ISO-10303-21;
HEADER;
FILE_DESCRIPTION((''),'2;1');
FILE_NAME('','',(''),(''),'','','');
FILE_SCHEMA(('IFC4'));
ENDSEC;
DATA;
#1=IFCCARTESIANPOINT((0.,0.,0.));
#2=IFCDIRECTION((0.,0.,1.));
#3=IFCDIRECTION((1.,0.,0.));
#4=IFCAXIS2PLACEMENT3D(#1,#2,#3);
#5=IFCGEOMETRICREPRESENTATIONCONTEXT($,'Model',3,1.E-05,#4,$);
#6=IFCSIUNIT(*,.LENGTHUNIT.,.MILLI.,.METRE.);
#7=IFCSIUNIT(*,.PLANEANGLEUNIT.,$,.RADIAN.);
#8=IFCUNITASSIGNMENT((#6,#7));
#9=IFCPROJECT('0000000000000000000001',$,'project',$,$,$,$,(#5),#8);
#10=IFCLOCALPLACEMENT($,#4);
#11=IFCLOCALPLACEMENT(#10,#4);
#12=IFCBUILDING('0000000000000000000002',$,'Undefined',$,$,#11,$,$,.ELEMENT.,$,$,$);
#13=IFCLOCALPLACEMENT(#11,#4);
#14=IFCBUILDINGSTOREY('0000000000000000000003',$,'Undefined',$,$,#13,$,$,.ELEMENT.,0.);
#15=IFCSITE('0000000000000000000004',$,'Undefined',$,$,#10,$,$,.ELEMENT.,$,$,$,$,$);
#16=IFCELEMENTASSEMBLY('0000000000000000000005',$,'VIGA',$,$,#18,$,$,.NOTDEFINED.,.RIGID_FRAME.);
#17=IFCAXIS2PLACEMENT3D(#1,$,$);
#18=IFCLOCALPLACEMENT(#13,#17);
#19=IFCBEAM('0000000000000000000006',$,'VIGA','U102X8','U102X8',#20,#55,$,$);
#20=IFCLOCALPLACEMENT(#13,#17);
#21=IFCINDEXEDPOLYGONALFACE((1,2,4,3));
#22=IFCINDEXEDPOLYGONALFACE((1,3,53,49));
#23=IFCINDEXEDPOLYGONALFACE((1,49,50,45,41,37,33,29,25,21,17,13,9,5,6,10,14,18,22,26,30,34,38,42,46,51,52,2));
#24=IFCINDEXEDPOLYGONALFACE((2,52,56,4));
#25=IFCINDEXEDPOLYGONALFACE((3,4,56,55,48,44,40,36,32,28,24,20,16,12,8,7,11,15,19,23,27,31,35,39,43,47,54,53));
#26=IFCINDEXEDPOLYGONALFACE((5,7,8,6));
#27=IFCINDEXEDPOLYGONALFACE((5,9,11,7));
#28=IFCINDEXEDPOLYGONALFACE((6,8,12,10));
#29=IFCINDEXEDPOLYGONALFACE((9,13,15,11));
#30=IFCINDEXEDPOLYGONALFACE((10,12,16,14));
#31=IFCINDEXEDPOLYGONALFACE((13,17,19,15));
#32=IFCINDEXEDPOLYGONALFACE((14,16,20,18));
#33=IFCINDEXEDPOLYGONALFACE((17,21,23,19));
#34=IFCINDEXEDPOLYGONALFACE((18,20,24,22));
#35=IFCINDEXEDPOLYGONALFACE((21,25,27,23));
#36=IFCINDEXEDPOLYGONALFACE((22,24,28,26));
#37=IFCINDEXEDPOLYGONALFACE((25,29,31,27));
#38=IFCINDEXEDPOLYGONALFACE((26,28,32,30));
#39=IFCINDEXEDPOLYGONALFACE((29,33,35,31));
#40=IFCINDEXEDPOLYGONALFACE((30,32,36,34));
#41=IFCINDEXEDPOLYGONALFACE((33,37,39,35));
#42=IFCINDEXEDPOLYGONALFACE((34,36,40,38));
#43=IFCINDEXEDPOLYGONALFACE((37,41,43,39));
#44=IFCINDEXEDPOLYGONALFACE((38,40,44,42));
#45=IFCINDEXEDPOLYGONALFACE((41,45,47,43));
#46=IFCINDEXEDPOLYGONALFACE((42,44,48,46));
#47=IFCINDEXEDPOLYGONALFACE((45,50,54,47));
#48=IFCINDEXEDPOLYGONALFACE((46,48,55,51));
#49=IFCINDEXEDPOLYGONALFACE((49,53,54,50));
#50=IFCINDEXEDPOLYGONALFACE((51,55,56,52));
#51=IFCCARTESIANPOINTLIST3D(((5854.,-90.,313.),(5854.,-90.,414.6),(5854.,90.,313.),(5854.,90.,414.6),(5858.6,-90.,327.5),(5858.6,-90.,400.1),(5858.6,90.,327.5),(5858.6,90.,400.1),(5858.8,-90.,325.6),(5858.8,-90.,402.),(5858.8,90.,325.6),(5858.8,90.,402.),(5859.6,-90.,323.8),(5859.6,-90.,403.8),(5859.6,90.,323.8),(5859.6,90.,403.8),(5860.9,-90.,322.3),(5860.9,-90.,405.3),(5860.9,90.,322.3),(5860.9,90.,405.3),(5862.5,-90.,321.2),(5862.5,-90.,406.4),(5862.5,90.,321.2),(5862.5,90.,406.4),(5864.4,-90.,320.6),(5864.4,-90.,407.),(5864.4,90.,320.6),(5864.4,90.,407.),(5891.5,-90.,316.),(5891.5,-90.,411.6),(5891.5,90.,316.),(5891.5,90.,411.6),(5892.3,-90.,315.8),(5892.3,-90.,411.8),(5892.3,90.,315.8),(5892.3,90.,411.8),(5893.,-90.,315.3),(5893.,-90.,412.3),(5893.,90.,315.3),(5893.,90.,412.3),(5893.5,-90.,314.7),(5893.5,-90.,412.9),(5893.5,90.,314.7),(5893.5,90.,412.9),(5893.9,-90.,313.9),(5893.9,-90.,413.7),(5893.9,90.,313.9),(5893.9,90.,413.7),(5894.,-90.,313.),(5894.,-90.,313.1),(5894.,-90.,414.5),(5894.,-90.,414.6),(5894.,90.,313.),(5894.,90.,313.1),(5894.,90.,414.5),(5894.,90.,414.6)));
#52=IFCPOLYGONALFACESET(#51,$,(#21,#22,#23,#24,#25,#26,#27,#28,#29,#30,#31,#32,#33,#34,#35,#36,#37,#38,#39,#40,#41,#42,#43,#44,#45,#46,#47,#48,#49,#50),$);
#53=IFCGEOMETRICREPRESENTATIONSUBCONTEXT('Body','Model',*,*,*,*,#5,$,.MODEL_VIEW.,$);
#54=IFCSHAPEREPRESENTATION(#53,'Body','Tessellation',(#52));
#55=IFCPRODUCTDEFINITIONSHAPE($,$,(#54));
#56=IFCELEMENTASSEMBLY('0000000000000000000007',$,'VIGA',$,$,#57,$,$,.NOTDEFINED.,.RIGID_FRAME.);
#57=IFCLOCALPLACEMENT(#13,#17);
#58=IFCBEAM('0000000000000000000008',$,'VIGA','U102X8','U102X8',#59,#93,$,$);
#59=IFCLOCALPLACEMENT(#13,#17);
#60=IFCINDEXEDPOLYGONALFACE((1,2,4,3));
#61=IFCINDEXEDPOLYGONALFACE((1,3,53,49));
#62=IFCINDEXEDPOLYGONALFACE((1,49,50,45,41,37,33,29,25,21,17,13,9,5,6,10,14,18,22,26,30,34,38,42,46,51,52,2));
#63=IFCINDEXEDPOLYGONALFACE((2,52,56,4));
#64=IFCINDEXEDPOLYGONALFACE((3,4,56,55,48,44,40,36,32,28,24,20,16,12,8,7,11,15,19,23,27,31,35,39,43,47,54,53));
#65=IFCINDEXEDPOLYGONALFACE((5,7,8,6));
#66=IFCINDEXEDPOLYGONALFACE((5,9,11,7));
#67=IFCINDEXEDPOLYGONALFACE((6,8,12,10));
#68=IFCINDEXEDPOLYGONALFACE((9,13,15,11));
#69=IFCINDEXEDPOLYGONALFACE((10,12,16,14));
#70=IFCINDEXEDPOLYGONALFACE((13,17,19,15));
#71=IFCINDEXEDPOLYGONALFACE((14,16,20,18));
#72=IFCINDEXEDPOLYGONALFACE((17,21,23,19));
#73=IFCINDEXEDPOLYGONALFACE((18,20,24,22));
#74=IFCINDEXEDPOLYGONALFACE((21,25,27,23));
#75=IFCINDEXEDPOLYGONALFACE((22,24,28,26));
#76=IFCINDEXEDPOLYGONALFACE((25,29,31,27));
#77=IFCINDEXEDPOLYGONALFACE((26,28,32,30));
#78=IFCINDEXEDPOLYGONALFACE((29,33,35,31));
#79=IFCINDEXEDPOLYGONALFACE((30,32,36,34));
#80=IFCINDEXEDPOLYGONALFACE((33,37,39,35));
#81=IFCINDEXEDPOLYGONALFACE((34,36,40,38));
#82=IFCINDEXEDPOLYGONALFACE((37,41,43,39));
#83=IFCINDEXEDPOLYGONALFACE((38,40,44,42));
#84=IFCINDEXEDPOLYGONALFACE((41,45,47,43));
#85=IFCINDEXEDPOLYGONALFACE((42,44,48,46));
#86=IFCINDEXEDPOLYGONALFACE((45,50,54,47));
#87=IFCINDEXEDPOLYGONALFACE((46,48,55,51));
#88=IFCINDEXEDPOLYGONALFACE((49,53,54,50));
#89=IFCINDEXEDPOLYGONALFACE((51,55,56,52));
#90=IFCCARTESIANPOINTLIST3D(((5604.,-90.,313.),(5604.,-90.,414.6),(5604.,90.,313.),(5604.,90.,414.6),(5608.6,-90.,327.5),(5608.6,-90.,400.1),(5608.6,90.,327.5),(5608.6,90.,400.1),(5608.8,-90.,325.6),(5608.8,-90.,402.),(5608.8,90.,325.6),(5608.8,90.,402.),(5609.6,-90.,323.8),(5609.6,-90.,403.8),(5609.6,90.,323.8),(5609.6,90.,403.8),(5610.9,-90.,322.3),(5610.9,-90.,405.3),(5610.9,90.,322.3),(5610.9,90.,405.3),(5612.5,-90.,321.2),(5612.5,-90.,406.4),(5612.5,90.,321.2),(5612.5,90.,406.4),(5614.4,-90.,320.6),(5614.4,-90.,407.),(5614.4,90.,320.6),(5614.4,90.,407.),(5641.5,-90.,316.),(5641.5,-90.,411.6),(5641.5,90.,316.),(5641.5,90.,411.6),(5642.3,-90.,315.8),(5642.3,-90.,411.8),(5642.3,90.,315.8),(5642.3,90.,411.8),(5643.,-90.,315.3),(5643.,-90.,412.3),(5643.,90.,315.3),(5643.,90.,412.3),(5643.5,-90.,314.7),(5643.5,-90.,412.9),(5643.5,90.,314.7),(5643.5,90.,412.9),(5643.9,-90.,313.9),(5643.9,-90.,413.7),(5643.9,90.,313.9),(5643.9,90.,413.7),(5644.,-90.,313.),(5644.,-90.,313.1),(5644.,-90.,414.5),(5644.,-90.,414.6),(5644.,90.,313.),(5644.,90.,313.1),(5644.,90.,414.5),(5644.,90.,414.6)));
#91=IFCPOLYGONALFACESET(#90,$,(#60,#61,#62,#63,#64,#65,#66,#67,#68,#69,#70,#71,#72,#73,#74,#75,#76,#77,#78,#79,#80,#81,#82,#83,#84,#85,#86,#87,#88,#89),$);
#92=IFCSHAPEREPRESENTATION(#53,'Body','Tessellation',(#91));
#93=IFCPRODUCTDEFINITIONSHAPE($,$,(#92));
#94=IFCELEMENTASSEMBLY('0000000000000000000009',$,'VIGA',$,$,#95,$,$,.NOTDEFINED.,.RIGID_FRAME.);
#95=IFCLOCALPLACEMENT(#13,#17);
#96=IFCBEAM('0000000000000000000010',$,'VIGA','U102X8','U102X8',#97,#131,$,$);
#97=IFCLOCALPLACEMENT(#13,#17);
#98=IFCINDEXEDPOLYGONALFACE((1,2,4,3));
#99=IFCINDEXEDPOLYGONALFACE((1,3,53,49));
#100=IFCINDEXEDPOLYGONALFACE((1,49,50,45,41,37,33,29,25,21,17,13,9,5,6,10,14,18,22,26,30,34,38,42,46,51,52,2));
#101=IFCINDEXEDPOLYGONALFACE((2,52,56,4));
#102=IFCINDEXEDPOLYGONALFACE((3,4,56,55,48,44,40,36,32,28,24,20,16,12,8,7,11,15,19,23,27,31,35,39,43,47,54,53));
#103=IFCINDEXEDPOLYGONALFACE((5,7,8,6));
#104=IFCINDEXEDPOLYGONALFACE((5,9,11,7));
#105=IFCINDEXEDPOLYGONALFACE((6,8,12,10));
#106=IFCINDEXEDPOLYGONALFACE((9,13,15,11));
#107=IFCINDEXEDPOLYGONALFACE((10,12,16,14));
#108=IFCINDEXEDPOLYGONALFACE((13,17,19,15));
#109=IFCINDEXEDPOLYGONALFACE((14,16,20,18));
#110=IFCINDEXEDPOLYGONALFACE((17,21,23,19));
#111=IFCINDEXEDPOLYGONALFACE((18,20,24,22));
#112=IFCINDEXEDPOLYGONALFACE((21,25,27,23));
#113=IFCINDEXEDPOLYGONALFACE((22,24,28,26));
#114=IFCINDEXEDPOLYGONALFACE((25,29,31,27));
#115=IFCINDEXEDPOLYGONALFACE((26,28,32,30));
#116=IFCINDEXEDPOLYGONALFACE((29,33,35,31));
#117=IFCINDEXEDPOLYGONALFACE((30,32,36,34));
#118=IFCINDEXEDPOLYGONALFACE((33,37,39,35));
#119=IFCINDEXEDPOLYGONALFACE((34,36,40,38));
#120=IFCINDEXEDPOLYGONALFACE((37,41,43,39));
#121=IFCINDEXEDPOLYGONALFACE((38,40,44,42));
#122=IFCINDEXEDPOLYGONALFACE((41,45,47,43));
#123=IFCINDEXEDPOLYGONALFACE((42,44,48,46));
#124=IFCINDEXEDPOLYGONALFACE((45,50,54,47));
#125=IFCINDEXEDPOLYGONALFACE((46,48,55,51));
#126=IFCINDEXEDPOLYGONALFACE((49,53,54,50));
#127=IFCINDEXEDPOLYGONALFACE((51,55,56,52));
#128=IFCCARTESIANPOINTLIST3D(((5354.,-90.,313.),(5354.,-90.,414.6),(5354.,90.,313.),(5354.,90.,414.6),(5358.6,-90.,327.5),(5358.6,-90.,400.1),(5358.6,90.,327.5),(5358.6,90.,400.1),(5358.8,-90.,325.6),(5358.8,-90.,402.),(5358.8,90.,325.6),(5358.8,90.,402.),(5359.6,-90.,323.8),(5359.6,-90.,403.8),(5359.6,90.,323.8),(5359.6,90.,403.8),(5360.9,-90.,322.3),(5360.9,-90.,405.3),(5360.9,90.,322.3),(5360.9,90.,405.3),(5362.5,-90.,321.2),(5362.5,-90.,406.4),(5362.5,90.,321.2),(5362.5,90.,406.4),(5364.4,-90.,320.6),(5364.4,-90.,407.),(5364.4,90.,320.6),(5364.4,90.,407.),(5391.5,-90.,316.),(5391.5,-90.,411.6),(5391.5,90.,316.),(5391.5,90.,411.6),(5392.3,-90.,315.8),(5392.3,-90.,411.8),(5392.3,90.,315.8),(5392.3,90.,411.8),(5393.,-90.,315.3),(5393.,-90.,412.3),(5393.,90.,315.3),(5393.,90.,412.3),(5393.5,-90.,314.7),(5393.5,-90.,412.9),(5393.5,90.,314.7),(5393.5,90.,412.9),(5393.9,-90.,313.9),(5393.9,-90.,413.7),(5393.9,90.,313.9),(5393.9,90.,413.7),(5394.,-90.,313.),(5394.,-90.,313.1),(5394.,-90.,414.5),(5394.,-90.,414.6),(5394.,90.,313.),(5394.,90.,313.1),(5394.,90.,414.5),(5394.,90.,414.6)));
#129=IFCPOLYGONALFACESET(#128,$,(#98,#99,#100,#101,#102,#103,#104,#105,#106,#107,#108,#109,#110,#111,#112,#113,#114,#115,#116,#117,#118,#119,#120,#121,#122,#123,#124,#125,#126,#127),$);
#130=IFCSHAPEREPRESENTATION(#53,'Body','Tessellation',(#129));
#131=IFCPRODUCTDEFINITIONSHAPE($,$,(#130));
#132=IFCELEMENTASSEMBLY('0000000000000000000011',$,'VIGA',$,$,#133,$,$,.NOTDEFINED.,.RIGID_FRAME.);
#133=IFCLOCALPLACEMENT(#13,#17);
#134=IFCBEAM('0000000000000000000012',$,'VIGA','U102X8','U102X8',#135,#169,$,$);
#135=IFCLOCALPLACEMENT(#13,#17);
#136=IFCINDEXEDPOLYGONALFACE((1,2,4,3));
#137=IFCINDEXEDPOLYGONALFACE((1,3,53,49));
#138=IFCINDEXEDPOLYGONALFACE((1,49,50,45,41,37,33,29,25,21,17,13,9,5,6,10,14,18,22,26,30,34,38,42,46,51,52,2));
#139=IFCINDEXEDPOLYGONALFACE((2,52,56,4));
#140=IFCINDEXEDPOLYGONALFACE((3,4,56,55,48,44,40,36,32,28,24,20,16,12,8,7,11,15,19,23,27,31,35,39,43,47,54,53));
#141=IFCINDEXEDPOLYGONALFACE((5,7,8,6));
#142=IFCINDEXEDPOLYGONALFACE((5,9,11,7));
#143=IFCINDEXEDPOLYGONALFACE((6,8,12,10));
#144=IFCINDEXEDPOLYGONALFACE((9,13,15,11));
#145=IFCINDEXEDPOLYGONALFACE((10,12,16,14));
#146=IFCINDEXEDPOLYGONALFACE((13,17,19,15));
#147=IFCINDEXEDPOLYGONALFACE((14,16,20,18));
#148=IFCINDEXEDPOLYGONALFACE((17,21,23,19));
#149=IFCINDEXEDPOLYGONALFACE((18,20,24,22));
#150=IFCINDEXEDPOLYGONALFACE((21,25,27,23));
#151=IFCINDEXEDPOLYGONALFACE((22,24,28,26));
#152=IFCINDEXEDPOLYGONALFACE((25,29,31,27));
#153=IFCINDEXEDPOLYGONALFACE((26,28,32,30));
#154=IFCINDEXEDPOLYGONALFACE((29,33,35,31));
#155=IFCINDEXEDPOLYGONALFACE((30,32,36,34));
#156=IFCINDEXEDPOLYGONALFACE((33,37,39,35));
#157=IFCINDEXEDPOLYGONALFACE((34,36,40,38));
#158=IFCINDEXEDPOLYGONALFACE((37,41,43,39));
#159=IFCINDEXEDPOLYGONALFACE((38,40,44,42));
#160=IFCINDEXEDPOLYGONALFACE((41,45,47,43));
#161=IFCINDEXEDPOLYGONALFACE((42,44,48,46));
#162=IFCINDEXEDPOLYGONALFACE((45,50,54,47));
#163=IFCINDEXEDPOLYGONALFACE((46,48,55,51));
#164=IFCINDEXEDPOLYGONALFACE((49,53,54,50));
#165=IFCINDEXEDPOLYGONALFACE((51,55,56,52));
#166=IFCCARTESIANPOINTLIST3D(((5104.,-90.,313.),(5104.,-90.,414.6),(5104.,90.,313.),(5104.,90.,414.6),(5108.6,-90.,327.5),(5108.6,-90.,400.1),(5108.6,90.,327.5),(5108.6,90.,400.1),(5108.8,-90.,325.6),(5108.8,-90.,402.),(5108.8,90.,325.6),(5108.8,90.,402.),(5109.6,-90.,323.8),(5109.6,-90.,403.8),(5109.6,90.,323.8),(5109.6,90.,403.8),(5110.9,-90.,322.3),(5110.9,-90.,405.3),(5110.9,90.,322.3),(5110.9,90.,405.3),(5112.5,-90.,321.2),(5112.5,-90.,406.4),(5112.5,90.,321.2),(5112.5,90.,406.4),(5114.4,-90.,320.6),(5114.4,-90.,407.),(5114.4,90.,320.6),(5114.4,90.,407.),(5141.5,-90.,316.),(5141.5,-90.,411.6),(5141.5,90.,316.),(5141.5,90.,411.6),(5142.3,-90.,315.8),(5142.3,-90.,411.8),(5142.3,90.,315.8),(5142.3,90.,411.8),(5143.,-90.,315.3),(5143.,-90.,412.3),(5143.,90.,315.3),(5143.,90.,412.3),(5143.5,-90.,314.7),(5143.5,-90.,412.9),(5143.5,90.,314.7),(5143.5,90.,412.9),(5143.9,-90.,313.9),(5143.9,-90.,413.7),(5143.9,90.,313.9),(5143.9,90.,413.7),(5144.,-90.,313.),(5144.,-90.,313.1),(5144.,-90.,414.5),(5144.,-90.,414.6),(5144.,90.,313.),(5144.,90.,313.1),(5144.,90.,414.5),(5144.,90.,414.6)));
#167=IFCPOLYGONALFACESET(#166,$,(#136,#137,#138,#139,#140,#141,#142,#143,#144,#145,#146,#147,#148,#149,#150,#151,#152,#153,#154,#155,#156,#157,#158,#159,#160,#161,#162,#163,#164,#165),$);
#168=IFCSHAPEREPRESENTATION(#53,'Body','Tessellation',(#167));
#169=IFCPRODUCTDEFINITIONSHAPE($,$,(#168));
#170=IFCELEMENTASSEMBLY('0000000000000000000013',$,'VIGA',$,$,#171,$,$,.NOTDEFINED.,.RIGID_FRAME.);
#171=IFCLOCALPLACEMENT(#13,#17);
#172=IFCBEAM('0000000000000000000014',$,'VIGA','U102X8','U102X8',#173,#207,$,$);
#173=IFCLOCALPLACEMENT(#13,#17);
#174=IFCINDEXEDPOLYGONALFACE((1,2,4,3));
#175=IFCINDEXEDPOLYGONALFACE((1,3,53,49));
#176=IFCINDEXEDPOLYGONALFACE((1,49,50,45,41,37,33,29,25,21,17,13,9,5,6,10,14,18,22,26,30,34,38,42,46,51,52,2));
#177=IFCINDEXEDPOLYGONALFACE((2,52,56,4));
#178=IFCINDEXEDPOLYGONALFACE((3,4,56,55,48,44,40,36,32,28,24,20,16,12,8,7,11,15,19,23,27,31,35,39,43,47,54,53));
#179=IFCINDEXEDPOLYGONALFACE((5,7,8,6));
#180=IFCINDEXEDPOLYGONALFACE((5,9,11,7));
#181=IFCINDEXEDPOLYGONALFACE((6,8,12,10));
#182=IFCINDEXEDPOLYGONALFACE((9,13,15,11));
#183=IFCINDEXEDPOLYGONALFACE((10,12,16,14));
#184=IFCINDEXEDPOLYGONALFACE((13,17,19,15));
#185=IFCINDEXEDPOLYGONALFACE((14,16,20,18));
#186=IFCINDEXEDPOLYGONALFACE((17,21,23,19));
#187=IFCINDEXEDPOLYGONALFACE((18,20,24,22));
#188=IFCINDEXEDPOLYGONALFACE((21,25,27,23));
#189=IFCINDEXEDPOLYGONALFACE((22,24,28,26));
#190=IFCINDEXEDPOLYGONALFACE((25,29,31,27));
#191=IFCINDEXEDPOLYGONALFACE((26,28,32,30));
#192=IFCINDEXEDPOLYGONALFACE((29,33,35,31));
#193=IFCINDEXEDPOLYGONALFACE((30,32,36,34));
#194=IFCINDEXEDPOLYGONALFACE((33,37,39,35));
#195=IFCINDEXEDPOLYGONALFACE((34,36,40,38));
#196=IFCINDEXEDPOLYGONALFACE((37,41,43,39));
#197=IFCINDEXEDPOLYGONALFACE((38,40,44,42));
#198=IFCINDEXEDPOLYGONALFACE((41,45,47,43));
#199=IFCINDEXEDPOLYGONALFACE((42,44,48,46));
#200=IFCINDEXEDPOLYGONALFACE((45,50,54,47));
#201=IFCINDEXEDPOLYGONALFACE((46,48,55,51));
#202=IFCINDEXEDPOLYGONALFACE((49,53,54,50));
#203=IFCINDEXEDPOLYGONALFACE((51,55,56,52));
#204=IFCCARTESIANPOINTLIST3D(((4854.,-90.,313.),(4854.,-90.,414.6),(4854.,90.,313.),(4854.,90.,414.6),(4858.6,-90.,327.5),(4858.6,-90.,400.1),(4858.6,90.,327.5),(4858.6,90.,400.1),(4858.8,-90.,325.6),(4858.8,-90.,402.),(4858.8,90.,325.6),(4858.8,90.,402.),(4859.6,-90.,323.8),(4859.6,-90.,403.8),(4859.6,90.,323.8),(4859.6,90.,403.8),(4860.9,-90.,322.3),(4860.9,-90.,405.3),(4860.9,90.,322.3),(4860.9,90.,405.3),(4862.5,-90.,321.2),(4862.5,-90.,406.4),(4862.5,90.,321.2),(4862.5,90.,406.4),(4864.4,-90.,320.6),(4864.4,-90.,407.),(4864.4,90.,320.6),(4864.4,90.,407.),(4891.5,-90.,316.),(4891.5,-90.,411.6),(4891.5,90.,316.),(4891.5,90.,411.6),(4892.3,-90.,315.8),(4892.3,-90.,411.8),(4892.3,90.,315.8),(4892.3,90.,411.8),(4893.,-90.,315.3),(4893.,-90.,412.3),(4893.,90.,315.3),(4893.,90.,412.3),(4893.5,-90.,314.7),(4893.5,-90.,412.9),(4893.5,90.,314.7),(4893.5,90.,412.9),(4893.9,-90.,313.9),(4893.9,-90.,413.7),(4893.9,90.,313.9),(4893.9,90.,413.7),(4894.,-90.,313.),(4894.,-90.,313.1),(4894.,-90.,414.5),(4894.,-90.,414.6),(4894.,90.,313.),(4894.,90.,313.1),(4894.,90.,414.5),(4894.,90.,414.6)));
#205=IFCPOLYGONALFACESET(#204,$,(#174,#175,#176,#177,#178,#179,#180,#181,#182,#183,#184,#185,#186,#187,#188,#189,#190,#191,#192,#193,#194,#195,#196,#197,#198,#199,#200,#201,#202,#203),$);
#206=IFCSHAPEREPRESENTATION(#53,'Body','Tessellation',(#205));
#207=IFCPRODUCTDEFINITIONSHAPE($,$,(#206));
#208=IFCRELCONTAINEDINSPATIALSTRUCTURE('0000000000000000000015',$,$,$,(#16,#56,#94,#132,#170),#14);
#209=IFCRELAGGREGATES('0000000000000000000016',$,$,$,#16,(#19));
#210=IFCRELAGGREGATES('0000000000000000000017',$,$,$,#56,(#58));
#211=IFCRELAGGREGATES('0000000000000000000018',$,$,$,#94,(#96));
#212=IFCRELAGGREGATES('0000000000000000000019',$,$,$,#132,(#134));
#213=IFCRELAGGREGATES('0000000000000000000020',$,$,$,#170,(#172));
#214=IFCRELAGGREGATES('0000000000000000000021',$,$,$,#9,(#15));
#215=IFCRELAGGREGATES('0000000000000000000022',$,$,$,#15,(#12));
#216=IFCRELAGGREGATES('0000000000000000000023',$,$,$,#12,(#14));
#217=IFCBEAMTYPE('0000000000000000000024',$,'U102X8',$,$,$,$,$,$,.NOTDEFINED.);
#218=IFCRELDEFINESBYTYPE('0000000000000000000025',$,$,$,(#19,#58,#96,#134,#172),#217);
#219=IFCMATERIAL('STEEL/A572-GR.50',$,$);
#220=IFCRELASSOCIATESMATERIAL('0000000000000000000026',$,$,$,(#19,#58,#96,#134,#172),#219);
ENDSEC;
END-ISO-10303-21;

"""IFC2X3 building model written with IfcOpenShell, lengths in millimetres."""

from ifc_helpers import new_model, si_unit, frame, origin_with_axes, origin_2d_with_axis, place, context, subcontext, project, spatial, u_section, extrude, material, type_object, element, aggregate, save


model = new_model("IFC2X3")

# Units and contexts
model_context = context("Model", 3, precision=1e-05, world=origin_with_axes())
body_context = subcontext(model_context, "Body", "Model", "MODEL_VIEW")
ifc_project = project(units=[si_unit("LENGTHUNIT", "METRE", prefix="MILLI"), si_unit("PLANEANGLEUNIT", "RADIAN")], contexts=[model_context])

# Site, building, storey
site_placement = place(None, origin_with_axes())
site = spatial("IfcSite", under=ifc_project, at=site_placement, Name="Undefined", CompositionType="ELEMENT")
building_placement = place(site_placement, origin_with_axes())
building = spatial("IfcBuilding", under=site, at=building_placement, Name="Undefined", CompositionType="ELEMENT")
storey_placement = place(building_placement, origin_with_axes())
storey = spatial("IfcBuildingStorey", under=building, at=storey_placement, Name="Undefined", CompositionType="ELEMENT", Elevation=0.0)

# Element assemblies, beams
ifc_material_1 = material(Name="STEEL/A572-GR.50")
beam_type_1 = type_object("IfcBeamType", Name="U102X8", PredefinedType="NOTDEFINED")
assembly_1_placement = place(storey_placement, origin_with_axes())
assembly_1 = element("IfcElementAssembly", 1, at=assembly_1_placement, inside=storey, Name="VIGA", AssemblyPlace="NOTDEFINED", PredefinedType="RIGID_FRAME")
beam_1_placement = place(assembly_1_placement, frame((5874.0, -90.0, 363.8), z_axis=(0.0, 0.0, 1.0), x_axis=(0.0, 1.0, 0.0)))
beam_1 = element("IfcBeam", 2, at=beam_1_placement, type_object=beam_type_1, material=ifc_material_1, Name="VIGA", Description="U102X8", ObjectType="U102X8", context=body_context, shape_type="SweptSolid", body=[
    extrude(u_section(Depth=101.6, FlangeWidth=40.0, WebThickness=4.6, FlangeThickness=6.0, FilletRadius=7.0, EdgeRadius=3.0, FlangeSlope=0.16839, at=origin_2d_with_axis()), frame((180.0, 0.0, 0.0), z_axis=(-1.0, 0.0, 0.0), x_axis=(0.0, -1.0, 0.0)), (0.0, 0.0, 1.0), 180.0),
])
aggregate(assembly_1, [beam_1])
assembly_2_placement = place(storey_placement, origin_with_axes())
assembly_2 = element("IfcElementAssembly", 3, at=assembly_2_placement, inside=storey, Name="VIGA", AssemblyPlace="NOTDEFINED", PredefinedType="RIGID_FRAME")
beam_2_placement = place(assembly_2_placement, frame((5624.0, -90.0, 363.8), z_axis=(0.0, 0.0, 1.0), x_axis=(0.0, 1.0, 0.0)))
beam_2 = element("IfcBeam", 4, at=beam_2_placement, type_object=beam_type_1, material=ifc_material_1, Name="VIGA", Description="U102X8", ObjectType="U102X8", context=body_context, shape_type="SweptSolid", body=[
    extrude(u_section(Depth=101.6, FlangeWidth=40.0, WebThickness=4.6, FlangeThickness=6.0, FilletRadius=7.0, EdgeRadius=3.0, FlangeSlope=0.16839, at=origin_2d_with_axis()), frame((180.0, 0.0, 0.0), z_axis=(-1.0, 0.0, 0.0), x_axis=(0.0, -1.0, 0.0)), (0.0, 0.0, 1.0), 180.0),
])
aggregate(assembly_2, [beam_2])
assembly_3_placement = place(storey_placement, origin_with_axes())
assembly_3 = element("IfcElementAssembly", 5, at=assembly_3_placement, inside=storey, Name="VIGA", AssemblyPlace="NOTDEFINED", PredefinedType="RIGID_FRAME")
beam_3_placement = place(assembly_3_placement, frame((5374.0, -90.0, 363.8), z_axis=(0.0, 0.0, 1.0), x_axis=(0.0, 1.0, 0.0)))
beam_3 = element("IfcBeam", 6, at=beam_3_placement, type_object=beam_type_1, material=ifc_material_1, Name="VIGA", Description="U102X8", ObjectType="U102X8", context=body_context, shape_type="SweptSolid", body=[
    extrude(u_section(Depth=101.6, FlangeWidth=40.0, WebThickness=4.6, FlangeThickness=6.0, FilletRadius=7.0, EdgeRadius=3.0, FlangeSlope=0.16839, at=origin_2d_with_axis()), frame((180.0, 0.0, 0.0), z_axis=(-1.0, 0.0, 0.0), x_axis=(0.0, -1.0, 0.0)), (0.0, 0.0, 1.0), 180.0),
])
aggregate(assembly_3, [beam_3])
assembly_4_placement = place(storey_placement, origin_with_axes())
assembly_4 = element("IfcElementAssembly", 7, at=assembly_4_placement, inside=storey, Name="VIGA", AssemblyPlace="NOTDEFINED", PredefinedType="RIGID_FRAME")
beam_4_placement = place(assembly_4_placement, frame((5124.0, -90.0, 363.8), z_axis=(0.0, 0.0, 1.0), x_axis=(0.0, 1.0, 0.0)))
beam_4 = element("IfcBeam", 8, at=beam_4_placement, type_object=beam_type_1, material=ifc_material_1, Name="VIGA", Description="U102X8", ObjectType="U102X8", context=body_context, shape_type="SweptSolid", body=[
    extrude(u_section(Depth=101.6, FlangeWidth=40.0, WebThickness=4.6, FlangeThickness=6.0, FilletRadius=7.0, EdgeRadius=3.0, FlangeSlope=0.16839, at=origin_2d_with_axis()), frame((180.0, 0.0, 0.0), z_axis=(-1.0, 0.0, 0.0), x_axis=(0.0, -1.0, 0.0)), (0.0, 0.0, 1.0), 180.0),
])
aggregate(assembly_4, [beam_4])
assembly_5_placement = place(storey_placement, origin_with_axes())
assembly_5 = element("IfcElementAssembly", 9, at=assembly_5_placement, inside=storey, Name="VIGA", AssemblyPlace="NOTDEFINED", PredefinedType="RIGID_FRAME")
beam_5_placement = place(assembly_5_placement, frame((4874.0, -90.0, 363.8), z_axis=(0.0, 0.0, 1.0), x_axis=(0.0, 1.0, 0.0)))
beam_5 = element("IfcBeam", 10, at=beam_5_placement, type_object=beam_type_1, material=ifc_material_1, Name="VIGA", Description="U102X8", ObjectType="U102X8", context=body_context, shape_type="SweptSolid", body=[
    extrude(u_section(Depth=101.6, FlangeWidth=40.0, WebThickness=4.6, FlangeThickness=6.0, FilletRadius=7.0, EdgeRadius=3.0, FlangeSlope=0.16839, at=origin_2d_with_axis()), frame((180.0, 0.0, 0.0), z_axis=(-1.0, 0.0, 0.0), x_axis=(0.0, -1.0, 0.0)), (0.0, 0.0, 1.0), 180.0),
])
aggregate(assembly_5, [beam_5])

save(model, "model.ifc")
